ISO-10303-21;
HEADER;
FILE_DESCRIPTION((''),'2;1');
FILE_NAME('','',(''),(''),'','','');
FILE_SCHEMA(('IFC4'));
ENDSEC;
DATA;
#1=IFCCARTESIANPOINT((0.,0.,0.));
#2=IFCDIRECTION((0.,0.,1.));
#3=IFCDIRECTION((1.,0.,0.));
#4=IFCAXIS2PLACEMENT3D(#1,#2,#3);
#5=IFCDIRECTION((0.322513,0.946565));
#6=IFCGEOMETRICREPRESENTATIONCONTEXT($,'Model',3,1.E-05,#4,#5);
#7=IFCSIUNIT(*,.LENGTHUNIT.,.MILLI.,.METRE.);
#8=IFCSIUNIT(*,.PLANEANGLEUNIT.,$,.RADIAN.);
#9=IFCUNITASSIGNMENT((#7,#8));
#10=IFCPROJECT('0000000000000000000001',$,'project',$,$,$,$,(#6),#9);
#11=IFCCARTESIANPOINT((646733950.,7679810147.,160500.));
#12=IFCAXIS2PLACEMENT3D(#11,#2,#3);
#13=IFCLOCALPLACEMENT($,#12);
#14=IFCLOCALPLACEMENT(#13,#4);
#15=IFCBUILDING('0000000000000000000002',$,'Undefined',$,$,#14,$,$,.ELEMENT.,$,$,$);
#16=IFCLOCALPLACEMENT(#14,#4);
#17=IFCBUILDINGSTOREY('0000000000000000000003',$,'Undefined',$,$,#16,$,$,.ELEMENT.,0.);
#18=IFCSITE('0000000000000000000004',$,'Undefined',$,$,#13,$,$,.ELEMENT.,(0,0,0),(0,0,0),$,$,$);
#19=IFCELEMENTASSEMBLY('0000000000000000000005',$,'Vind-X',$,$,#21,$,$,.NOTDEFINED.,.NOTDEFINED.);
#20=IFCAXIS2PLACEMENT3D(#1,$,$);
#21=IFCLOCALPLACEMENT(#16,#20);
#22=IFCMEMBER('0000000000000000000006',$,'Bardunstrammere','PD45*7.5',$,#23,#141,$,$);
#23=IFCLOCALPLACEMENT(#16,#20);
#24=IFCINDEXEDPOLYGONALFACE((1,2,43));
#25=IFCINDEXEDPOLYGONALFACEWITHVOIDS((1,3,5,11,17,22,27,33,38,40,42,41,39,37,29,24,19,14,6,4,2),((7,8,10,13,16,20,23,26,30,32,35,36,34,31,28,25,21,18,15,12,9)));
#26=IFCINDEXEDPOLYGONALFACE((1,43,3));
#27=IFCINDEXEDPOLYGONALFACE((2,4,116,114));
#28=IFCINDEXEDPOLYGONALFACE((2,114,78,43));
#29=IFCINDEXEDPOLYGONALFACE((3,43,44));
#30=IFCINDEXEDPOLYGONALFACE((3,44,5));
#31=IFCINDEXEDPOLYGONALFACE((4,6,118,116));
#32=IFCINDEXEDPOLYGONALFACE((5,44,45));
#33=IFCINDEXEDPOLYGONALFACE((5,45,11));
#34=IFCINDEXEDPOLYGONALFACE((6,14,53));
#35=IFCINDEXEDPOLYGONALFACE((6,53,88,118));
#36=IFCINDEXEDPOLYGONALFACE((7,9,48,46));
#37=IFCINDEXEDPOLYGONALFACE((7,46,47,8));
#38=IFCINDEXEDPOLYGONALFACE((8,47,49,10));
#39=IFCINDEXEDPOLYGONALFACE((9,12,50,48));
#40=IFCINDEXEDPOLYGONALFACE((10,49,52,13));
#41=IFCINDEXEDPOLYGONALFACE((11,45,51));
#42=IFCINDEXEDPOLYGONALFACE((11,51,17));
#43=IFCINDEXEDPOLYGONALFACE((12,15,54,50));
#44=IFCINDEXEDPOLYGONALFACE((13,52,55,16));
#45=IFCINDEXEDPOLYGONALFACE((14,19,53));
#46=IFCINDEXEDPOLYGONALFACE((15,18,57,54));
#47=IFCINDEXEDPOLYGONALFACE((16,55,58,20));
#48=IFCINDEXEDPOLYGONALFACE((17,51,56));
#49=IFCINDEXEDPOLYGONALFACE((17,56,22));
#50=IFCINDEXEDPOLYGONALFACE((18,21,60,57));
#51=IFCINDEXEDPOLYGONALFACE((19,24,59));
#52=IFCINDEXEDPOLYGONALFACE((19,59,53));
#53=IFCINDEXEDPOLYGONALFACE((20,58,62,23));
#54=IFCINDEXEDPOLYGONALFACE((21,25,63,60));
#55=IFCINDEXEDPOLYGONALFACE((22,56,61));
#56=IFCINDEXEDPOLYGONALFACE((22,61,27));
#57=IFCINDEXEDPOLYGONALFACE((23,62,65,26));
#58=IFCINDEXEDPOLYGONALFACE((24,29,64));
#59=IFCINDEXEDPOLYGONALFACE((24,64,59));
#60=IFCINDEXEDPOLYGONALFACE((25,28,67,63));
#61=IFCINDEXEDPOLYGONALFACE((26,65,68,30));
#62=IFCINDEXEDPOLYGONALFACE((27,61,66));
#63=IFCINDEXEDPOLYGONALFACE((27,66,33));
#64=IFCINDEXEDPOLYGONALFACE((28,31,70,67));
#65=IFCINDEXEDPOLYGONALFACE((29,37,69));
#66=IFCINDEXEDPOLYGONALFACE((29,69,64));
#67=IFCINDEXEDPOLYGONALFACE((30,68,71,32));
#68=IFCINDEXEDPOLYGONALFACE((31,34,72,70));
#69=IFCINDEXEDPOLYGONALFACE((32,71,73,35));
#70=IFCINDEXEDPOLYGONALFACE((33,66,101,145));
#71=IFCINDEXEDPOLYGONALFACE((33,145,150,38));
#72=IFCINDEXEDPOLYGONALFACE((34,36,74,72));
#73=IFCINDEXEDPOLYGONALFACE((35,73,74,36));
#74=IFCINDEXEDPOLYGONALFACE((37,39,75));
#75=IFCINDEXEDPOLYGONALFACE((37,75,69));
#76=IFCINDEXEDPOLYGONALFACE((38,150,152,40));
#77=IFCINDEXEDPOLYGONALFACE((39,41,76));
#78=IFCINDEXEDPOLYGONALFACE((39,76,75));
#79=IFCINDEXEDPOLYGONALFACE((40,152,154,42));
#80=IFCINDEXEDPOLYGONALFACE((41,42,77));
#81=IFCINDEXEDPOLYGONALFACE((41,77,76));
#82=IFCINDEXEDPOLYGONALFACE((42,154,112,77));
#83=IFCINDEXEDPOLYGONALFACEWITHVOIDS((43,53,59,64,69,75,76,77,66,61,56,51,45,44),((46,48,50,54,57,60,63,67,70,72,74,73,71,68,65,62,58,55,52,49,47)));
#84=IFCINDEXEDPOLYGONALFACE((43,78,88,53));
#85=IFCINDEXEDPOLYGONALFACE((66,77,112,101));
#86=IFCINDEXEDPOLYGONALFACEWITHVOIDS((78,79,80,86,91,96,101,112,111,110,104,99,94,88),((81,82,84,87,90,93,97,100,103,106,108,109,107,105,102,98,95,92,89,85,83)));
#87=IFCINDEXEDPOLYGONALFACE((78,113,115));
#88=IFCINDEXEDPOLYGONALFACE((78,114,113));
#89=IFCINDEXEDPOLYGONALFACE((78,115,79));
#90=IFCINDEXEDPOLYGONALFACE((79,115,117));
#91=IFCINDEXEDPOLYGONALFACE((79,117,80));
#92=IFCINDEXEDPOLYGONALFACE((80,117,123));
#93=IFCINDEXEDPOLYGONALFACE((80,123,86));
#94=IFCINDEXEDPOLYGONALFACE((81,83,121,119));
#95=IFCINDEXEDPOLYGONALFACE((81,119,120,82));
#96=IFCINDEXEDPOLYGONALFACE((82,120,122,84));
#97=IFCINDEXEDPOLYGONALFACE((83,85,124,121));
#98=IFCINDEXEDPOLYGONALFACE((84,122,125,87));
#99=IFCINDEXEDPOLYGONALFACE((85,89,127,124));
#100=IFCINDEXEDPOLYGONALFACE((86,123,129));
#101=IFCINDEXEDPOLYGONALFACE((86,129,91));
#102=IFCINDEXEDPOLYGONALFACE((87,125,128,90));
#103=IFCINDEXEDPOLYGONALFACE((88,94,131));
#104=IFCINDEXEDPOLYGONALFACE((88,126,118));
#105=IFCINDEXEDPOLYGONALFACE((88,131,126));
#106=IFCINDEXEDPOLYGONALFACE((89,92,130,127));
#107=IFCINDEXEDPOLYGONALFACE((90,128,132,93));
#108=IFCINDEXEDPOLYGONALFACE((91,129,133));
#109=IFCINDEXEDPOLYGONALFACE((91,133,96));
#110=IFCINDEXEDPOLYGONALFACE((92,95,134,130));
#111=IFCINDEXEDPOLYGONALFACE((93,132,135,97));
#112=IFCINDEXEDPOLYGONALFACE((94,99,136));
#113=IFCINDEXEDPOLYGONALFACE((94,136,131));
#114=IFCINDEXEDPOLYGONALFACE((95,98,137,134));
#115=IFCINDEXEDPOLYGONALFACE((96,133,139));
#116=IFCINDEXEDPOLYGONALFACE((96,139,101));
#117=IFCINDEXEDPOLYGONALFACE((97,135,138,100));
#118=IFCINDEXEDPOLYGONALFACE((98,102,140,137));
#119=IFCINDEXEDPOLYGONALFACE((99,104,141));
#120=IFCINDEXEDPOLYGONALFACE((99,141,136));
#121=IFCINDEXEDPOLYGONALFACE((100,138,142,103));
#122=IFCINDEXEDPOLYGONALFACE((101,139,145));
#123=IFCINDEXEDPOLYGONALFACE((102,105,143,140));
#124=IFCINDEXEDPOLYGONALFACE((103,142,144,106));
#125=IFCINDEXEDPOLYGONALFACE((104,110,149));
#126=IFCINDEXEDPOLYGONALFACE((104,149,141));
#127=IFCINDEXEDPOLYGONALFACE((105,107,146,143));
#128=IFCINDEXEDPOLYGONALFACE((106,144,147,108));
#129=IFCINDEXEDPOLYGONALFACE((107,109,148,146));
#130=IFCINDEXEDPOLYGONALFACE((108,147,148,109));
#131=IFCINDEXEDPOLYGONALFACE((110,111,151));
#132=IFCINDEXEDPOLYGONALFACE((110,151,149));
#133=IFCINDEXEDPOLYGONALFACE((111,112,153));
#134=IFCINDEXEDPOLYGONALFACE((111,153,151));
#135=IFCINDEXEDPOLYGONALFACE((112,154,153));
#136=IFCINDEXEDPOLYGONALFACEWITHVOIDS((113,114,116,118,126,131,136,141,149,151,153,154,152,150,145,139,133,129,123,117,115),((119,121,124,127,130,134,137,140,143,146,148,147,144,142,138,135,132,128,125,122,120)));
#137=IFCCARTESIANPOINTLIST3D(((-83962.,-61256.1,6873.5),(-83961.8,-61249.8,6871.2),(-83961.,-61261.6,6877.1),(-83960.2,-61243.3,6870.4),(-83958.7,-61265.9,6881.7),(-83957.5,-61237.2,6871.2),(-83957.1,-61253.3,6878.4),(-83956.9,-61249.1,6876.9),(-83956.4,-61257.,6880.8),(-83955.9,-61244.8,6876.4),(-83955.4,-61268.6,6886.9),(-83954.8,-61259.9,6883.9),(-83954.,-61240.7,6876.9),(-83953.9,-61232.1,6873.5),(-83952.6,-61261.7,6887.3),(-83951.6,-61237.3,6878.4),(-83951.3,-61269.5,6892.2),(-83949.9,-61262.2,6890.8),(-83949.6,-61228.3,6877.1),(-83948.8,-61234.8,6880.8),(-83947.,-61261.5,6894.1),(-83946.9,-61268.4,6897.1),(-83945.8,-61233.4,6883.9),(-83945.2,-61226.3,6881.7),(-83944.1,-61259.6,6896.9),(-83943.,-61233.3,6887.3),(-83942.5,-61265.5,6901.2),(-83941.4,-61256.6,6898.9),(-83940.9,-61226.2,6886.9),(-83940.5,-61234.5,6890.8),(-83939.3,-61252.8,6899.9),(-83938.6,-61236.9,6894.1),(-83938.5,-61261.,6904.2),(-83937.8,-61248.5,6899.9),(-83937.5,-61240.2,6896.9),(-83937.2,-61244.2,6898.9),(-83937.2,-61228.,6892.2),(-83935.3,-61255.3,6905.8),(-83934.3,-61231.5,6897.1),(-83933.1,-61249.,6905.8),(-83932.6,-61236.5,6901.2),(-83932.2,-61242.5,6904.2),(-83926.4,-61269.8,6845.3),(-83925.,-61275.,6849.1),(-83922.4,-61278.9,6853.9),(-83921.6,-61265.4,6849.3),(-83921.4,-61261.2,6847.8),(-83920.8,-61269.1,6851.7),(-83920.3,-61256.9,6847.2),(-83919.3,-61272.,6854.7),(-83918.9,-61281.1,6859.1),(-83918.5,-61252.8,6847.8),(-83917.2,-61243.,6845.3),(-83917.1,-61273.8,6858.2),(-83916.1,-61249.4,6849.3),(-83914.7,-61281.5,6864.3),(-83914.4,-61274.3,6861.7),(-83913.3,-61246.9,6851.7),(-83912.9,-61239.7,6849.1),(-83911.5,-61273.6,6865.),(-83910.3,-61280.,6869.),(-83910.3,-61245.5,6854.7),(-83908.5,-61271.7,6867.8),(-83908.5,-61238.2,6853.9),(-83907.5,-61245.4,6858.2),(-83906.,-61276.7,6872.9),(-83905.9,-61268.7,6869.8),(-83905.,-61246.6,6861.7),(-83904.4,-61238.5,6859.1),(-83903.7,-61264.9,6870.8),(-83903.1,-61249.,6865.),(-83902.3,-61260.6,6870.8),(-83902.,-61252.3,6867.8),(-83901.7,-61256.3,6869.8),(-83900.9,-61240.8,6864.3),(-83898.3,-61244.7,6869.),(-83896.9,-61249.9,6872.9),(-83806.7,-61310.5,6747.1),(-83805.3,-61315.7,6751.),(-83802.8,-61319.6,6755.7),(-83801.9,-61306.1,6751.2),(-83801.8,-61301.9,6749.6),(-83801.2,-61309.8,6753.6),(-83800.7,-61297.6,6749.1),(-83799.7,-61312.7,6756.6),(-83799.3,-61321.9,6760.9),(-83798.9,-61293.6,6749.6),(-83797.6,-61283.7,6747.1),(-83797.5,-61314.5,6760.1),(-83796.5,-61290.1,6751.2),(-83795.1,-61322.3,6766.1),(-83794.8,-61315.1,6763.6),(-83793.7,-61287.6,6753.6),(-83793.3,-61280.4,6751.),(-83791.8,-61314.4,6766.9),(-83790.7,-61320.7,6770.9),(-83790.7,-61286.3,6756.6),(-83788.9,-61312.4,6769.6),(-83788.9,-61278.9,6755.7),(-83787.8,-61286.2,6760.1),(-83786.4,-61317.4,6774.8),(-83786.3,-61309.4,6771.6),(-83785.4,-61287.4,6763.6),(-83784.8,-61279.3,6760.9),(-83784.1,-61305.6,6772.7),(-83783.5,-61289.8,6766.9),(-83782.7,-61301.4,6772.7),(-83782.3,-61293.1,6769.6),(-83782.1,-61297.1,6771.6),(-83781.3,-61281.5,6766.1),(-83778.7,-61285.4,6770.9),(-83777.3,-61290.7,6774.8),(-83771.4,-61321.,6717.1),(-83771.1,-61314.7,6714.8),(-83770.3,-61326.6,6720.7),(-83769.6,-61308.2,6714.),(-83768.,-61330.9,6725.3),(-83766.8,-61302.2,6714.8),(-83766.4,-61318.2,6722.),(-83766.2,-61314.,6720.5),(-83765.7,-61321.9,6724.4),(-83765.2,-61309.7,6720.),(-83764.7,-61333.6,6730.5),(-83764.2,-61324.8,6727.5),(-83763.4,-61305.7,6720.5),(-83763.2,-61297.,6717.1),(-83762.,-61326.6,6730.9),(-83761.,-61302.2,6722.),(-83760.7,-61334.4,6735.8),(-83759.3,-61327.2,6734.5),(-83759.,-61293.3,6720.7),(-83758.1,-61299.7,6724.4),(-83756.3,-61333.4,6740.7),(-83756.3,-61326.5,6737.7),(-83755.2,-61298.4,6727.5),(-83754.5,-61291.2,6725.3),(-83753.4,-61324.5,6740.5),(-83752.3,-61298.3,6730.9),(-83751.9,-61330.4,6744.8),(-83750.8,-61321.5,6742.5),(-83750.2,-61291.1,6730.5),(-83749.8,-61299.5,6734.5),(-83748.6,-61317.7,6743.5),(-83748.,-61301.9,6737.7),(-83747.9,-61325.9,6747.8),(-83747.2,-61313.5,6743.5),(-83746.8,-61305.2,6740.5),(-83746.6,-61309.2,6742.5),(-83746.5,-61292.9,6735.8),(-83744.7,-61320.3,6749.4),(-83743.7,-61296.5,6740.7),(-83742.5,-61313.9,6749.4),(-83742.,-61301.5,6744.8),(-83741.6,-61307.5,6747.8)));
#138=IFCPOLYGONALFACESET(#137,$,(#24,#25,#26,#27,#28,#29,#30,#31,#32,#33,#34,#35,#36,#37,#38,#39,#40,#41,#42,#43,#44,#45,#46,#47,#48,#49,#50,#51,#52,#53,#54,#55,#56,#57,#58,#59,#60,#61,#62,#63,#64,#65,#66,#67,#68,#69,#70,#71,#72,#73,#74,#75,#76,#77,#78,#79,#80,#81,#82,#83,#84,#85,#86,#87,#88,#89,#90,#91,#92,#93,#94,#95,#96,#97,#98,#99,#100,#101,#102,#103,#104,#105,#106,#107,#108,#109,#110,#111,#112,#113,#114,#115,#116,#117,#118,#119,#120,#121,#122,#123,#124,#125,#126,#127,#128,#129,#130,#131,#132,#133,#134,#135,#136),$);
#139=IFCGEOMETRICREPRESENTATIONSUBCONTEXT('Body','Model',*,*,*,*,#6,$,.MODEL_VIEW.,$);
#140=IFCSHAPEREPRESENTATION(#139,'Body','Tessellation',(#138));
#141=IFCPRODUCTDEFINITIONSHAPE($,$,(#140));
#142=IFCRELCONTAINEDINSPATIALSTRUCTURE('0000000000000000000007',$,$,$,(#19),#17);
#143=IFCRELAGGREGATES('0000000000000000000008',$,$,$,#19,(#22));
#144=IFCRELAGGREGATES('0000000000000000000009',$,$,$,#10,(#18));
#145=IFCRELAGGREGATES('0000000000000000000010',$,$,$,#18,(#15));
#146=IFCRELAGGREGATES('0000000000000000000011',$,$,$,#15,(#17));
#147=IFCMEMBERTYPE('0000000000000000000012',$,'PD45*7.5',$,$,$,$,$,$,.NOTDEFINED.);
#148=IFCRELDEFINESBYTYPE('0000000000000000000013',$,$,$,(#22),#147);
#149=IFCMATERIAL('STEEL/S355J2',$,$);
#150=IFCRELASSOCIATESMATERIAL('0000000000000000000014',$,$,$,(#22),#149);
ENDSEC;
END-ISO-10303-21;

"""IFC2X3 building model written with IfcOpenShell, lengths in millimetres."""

from ifc_helpers import new_model, si_unit, direction, frame, origin_with_axes, origin_2d_with_axis, place, context, subcontext, project, spatial, rectangle, hollow_circle, extrude, boolean, material, type_object, element, aggregate, save


model = new_model("IFC2X3")

# Units and contexts
model_context = context("Model", 3, precision=1e-05, world=origin_with_axes(), true_north=direction((0.322513, 0.946565)))
body_context = subcontext(model_context, "Body", "Model", "MODEL_VIEW")
ifc_project = project(units=[si_unit("LENGTHUNIT", "METRE", prefix="MILLI"), si_unit("PLANEANGLEUNIT", "RADIAN")], contexts=[model_context])

# Site, building, storey
site_placement = place(None, frame((646733950.0, 7679810147.0, 160500.0), z_axis=(0.0, 0.0, 1.0), x_axis=(1.0, 0.0, 0.0)))
site = spatial("IfcSite", under=ifc_project, at=site_placement, Name="Undefined", CompositionType="ELEMENT", RefLatitude=(0, 0, 0), RefLongitude=(0, 0, 0))
building_placement = place(site_placement, origin_with_axes())
building = spatial("IfcBuilding", under=site, at=building_placement, Name="Undefined", CompositionType="ELEMENT")
storey_placement = place(building_placement, origin_with_axes())
storey = spatial("IfcBuildingStorey", under=building, at=storey_placement, Name="Undefined", CompositionType="ELEMENT", Elevation=0.0)

# Element assembly
assembly_1_placement = place(storey_placement, origin_with_axes())
assembly_1 = element("IfcElementAssembly", 1, at=assembly_1_placement, inside=storey, Name="Vind-X", AssemblyPlace="NOTDEFINED", PredefinedType="NOTDEFINED")
ifc_material_1 = material(Name="STEEL/S355J2")

# Member
member_type_1 = type_object("IfcMemberType", Name="PD45*7.5", PredefinedType="NOTDEFINED")
member_1_placement = place(assembly_1_placement, frame((-83947.1, -61247.7, 6888.2), z_axis=(-0.322513, -0.946565, 0.0), x_axis=(0.747634, -0.254733, -0.613314)))
member_1 = element("IfcMember", 2, at=member_1_placement, type_object=member_type_1, material=ifc_material_1, Name="Bardunstrammere", Description="PD45*7.5", context=body_context, shape_type="CSG", body=[
    boolean("DIFFERENCE", extrude(hollow_circle(Radius=22.5, WallThickness=7.5, at=origin_2d_with_axis()), frame((255.0, 0.0, 0.0), z_axis=(-1.0, 0.0, 0.0), x_axis=(0.0, -1.0, 0.0)), (0.0, 0.0, 1.0), 255.0), extrude(rectangle(XDim=35.0, YDim=90.0, at=origin_2d_with_axis()), frame((207.5, 0.0, 0.0), z_axis=(-1.0, 0.0, 0.0), x_axis=(0.0, -1.0, 0.0)), (0.0, 0.0, 1.0), 160.0)),
])
aggregate(assembly_1, [member_1])

save(model, "model.ifc")
